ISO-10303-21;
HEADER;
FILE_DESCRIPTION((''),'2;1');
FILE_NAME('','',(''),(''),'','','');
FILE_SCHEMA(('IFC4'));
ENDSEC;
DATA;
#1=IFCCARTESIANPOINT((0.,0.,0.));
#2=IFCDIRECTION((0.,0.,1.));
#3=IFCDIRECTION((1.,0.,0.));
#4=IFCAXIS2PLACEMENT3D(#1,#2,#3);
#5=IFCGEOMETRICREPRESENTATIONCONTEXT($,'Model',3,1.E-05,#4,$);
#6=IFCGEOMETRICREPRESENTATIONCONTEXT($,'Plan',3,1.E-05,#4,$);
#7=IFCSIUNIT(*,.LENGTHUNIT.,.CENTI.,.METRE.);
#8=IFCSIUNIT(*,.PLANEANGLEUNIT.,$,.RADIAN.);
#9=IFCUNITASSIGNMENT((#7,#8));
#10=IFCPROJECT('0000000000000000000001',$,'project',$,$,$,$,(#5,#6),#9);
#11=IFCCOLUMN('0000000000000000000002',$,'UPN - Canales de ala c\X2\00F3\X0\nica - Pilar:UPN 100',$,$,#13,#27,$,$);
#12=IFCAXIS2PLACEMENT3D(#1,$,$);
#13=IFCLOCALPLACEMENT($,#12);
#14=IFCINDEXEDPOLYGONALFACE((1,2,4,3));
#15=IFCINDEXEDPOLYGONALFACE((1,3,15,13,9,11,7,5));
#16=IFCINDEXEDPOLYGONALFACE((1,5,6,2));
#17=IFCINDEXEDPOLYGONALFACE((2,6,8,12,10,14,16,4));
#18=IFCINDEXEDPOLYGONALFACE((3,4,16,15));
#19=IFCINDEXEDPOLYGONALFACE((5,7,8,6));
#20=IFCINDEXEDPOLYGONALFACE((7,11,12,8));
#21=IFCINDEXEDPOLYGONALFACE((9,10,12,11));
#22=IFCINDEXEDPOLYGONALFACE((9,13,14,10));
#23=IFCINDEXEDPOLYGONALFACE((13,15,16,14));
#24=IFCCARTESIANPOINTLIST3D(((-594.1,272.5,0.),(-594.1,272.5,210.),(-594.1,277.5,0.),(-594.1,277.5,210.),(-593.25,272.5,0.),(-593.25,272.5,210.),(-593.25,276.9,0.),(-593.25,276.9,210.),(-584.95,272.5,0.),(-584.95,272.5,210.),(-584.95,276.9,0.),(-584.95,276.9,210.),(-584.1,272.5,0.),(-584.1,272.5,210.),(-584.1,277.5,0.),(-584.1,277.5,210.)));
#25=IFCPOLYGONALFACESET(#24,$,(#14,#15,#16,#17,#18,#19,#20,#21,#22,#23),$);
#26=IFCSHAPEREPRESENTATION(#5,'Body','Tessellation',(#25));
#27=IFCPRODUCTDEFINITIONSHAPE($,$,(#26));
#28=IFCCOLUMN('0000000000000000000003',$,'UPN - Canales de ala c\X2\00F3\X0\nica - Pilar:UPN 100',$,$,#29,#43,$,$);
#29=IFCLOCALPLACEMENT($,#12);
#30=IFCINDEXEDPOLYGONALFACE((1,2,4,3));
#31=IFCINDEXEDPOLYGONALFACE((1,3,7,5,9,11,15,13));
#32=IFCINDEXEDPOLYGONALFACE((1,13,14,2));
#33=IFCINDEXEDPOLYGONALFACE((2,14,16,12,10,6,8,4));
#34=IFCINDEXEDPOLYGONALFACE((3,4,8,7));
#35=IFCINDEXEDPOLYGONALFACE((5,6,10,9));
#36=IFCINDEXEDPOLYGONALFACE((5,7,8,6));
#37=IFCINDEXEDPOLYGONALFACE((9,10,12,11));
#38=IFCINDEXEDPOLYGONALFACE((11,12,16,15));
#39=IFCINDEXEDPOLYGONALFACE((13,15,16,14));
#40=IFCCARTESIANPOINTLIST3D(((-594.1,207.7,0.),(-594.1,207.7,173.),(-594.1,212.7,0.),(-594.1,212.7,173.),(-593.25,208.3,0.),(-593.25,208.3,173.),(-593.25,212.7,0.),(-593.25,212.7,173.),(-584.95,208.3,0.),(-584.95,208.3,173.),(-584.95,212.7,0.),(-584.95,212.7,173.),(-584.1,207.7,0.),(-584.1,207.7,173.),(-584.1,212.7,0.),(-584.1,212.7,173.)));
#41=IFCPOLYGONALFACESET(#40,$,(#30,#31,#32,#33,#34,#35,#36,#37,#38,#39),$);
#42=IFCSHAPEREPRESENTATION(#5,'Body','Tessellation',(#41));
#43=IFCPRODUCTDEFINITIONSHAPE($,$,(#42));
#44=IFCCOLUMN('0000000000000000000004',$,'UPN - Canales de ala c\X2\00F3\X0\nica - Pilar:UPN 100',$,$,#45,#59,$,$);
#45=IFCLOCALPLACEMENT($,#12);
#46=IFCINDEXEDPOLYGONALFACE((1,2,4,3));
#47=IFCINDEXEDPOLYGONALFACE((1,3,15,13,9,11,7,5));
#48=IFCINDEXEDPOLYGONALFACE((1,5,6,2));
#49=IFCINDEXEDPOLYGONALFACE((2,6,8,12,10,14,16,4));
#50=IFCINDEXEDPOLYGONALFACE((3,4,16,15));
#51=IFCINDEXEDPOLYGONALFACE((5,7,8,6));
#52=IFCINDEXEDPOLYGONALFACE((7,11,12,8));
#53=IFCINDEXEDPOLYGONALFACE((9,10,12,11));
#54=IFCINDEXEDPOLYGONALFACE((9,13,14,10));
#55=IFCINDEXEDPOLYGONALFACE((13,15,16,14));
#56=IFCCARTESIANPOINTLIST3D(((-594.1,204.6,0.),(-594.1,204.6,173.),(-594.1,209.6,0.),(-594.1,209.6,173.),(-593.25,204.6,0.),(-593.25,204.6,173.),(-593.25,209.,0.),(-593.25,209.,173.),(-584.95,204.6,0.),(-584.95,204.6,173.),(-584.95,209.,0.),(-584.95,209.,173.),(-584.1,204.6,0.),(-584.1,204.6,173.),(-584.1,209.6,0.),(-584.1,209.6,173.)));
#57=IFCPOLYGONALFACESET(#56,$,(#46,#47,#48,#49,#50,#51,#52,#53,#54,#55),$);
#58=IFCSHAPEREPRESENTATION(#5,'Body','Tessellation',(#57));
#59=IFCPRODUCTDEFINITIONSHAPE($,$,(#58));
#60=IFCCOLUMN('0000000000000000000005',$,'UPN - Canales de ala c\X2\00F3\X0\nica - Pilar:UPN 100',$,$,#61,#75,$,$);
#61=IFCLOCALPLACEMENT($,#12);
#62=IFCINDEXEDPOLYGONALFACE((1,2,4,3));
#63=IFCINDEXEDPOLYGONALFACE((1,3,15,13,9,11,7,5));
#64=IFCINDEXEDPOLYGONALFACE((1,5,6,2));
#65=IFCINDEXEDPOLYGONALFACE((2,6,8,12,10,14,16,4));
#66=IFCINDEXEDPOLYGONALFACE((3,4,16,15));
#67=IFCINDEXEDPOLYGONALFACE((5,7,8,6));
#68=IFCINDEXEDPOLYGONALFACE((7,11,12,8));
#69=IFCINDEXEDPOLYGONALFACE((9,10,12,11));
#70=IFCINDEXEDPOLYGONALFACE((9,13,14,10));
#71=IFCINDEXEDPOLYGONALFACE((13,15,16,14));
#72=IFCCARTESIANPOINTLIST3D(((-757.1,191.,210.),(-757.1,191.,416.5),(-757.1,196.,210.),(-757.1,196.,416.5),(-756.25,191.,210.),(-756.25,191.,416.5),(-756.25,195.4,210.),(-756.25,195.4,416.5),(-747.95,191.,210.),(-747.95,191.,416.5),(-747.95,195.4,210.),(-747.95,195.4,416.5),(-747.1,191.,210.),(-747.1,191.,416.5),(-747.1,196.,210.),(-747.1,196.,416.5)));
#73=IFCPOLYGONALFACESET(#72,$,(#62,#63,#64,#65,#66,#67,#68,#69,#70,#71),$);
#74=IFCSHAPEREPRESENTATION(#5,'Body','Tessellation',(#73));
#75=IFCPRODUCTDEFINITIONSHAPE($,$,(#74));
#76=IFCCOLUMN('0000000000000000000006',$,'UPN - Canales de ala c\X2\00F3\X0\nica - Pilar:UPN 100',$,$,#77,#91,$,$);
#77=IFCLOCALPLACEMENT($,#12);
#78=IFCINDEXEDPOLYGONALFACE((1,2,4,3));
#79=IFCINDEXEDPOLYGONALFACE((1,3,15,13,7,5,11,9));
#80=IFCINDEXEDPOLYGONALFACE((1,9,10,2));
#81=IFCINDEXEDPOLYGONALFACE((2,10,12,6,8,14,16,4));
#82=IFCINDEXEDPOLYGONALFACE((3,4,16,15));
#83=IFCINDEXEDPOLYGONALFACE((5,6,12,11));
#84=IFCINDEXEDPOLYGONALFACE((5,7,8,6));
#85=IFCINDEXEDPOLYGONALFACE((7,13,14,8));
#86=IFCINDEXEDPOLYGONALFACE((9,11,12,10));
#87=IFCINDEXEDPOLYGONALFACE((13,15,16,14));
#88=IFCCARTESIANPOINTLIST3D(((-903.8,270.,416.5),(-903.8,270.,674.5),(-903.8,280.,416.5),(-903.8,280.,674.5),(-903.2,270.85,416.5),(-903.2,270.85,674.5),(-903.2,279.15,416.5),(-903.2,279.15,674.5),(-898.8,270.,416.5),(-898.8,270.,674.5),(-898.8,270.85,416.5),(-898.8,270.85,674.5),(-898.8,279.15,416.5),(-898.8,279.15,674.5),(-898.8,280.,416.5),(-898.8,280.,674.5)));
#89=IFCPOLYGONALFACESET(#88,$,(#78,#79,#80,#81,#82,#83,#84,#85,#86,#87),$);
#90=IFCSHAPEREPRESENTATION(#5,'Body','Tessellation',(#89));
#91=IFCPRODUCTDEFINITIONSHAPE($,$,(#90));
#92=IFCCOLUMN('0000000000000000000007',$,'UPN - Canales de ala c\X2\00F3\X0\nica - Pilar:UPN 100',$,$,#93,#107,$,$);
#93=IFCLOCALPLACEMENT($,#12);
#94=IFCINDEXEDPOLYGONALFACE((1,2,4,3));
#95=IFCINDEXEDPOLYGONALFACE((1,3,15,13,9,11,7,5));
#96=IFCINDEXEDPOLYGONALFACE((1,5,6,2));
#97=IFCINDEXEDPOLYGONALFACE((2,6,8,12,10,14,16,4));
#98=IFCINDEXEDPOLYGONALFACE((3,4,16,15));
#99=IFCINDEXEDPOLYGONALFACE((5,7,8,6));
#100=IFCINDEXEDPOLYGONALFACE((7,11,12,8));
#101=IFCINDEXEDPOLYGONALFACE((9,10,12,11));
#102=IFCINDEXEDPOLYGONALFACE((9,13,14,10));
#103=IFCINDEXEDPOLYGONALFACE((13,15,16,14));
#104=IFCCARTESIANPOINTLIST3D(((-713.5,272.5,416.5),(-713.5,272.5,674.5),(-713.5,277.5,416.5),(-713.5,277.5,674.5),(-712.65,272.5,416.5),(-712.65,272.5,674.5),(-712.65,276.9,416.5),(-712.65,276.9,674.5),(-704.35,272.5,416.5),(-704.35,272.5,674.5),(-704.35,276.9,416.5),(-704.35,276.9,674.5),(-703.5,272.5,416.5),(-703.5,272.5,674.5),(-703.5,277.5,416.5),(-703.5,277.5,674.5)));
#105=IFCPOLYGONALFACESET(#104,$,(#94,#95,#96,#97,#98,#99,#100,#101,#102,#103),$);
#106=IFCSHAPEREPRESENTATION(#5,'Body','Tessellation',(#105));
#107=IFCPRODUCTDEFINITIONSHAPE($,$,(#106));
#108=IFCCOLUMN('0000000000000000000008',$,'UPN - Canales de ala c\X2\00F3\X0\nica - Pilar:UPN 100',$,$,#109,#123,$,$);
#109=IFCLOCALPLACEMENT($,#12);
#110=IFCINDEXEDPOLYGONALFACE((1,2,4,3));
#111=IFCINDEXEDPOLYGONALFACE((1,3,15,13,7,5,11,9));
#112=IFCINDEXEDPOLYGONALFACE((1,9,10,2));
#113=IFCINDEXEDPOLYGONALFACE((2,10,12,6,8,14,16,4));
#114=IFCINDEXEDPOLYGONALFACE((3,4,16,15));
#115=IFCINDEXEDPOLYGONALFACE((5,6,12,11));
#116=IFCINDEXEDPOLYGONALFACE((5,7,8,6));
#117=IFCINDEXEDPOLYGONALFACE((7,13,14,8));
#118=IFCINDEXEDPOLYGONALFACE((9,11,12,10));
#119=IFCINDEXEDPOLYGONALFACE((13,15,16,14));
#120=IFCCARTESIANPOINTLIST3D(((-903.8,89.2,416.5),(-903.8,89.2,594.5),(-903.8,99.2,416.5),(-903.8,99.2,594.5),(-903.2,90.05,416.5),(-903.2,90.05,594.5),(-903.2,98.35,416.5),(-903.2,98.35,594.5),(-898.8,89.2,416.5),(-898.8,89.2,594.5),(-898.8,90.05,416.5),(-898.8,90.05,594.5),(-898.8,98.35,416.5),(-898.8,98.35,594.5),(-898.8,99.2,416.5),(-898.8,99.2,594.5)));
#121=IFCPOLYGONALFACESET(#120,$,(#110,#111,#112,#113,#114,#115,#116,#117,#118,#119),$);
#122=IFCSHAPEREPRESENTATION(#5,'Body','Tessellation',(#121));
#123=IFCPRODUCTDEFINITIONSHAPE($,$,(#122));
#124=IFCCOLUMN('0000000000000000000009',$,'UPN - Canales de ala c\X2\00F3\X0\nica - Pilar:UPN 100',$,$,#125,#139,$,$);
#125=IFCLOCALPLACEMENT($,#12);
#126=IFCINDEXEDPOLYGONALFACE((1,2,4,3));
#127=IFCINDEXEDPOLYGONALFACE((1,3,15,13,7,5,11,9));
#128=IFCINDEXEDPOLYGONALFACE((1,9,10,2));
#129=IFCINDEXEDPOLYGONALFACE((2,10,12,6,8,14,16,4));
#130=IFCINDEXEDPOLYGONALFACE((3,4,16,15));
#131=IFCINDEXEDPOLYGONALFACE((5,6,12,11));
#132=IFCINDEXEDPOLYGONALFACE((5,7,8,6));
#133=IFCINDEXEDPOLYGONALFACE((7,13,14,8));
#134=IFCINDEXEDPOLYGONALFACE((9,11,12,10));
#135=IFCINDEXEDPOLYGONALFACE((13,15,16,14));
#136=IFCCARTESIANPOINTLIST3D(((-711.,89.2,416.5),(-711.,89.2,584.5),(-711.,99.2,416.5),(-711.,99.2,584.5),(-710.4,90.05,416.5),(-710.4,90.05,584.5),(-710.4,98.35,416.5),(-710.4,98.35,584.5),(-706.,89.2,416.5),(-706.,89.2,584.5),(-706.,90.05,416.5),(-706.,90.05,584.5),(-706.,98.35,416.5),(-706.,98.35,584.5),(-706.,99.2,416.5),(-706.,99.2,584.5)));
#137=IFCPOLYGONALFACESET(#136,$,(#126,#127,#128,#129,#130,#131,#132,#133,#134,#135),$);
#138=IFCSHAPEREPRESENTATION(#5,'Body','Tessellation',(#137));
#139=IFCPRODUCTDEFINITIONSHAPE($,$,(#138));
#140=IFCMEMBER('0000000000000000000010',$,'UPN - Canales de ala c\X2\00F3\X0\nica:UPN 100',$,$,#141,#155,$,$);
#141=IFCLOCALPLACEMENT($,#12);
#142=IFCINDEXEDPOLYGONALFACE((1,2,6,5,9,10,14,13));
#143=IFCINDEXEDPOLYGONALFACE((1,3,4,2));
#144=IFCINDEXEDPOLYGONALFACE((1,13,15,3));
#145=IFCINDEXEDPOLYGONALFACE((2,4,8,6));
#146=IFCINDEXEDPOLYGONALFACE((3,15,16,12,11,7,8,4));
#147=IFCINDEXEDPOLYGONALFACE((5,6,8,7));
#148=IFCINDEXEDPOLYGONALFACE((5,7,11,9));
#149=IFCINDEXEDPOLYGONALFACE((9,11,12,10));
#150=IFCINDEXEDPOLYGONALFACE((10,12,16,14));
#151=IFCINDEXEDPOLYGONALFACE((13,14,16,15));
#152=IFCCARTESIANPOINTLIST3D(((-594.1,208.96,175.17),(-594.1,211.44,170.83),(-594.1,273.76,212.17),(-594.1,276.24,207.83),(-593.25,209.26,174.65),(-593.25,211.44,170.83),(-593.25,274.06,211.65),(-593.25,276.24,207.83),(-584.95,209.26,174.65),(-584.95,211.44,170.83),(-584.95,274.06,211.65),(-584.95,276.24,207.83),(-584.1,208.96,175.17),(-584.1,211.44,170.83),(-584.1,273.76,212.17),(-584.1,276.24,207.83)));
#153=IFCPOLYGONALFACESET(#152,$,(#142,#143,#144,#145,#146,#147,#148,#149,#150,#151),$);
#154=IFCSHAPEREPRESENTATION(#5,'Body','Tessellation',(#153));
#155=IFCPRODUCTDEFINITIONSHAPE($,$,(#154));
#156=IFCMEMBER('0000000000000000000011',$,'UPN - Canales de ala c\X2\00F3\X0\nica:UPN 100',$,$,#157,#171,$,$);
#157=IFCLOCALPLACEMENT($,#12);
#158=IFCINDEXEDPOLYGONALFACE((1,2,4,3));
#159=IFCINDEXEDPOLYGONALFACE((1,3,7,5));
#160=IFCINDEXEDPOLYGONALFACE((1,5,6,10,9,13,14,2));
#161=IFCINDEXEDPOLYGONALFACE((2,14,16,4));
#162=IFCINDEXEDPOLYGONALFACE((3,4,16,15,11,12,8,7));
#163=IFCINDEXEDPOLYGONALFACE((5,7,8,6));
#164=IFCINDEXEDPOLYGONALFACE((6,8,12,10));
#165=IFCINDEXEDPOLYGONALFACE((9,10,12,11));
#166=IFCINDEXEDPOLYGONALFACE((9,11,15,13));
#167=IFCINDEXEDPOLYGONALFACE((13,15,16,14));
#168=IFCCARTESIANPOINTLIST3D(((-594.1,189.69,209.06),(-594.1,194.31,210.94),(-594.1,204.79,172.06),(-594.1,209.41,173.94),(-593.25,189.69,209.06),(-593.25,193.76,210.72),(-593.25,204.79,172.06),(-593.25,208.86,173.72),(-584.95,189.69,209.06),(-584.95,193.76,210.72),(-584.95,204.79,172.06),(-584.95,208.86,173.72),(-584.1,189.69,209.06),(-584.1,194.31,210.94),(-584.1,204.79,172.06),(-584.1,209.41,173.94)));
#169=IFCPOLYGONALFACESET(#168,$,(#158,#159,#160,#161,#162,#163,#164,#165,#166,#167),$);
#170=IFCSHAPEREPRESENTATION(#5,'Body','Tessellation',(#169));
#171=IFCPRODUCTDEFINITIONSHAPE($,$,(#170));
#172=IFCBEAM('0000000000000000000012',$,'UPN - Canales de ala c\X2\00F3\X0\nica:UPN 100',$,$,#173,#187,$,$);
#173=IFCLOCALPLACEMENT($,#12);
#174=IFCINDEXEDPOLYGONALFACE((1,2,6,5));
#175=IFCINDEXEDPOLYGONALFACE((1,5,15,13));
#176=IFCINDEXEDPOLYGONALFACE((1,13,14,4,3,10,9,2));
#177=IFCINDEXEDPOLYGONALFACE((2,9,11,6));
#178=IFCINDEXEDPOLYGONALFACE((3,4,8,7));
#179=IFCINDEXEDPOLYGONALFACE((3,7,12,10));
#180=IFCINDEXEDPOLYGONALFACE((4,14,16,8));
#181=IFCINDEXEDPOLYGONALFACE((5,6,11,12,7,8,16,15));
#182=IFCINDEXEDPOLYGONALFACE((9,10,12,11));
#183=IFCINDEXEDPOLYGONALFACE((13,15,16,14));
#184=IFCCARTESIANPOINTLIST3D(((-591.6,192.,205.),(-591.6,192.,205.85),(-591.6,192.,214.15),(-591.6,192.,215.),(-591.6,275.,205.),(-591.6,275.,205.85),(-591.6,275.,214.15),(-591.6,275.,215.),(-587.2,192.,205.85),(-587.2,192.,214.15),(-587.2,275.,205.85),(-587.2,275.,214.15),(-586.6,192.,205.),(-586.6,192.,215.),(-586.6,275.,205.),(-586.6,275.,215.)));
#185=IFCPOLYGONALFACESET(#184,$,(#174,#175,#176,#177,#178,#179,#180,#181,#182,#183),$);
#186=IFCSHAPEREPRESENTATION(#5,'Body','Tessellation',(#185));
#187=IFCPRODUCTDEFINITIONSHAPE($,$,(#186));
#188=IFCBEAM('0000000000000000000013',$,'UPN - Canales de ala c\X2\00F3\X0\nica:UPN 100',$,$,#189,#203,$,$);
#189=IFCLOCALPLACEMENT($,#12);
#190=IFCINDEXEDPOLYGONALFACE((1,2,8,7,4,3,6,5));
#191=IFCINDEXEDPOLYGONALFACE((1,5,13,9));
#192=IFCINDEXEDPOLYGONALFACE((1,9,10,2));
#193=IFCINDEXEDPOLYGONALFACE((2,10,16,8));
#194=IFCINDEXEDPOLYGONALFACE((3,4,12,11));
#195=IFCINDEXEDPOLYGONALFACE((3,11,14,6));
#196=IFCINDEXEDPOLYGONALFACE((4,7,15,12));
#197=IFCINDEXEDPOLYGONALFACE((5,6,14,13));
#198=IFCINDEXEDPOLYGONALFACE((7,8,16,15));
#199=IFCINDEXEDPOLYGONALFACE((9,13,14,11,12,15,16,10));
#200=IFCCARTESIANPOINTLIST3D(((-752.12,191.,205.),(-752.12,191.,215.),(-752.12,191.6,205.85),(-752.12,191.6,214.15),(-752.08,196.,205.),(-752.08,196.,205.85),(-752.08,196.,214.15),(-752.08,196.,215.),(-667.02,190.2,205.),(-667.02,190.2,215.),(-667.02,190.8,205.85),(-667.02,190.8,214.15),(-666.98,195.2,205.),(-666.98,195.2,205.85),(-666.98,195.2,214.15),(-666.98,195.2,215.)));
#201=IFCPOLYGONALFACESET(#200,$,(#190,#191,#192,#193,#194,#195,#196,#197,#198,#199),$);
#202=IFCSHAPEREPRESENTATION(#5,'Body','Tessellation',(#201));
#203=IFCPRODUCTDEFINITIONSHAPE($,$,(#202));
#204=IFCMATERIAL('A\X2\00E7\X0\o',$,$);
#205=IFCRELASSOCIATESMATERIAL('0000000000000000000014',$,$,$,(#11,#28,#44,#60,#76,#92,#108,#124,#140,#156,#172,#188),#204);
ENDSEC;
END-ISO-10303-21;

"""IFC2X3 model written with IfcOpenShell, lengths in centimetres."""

from ifc_helpers import new_model, si_unit, frame, frame_2d, origin_with_axes, origin_2d_with_axis, place, context, project, u_section, extrude, material, element, save


model = new_model("IFC2X3")

# Units and contexts
model_context = context("Model", 3, precision=1e-05, world=origin_with_axes())
plan_context = context("Plan", 3, precision=1e-05, world=origin_with_axes())
ifc_project = project(units=[si_unit("LENGTHUNIT", "METRE", prefix="CENTI"), si_unit("PLANEANGLEUNIT", "RADIAN")], contexts=[model_context, plan_context])

# Columns
ifc_material = material(Name="Aço")
column_1_placement = place(None, frame((-589.1, 275.0, 0.0), z_axis=(0.0, 0.0, 1.0), x_axis=(0.0, -1.0, 0.0)))
element("IfcColumn", 1, at=column_1_placement, material=ifc_material, Name="UPN - Canales de ala cónica - Pilar:UPN 100", context=model_context, shape_type="SweptSolid", body=[
    extrude(u_section(Depth=10.0, FlangeWidth=5.0, WebThickness=0.6, FlangeThickness=0.85, FilletRadius=0.0, EdgeRadius=0.0, FlangeSlope=0.0, CentreOfGravityInX=0.0, at=origin_2d_with_axis()), origin_with_axes(), (0.0, 0.0, 1.0), 210.0),
])
for number, where, z_axis, x_axis, name in (
    (2, (-589.1, 210.2, 0.0), (0.0, 0.0, 1.0), (0.0, 1.0, 0.0), "UPN - Canales de ala cónica - Pilar:UPN 100"),
    (3, (-589.1, 207.1, 0.0), (0.0, 0.0, 1.0), (0.0, -1.0, 0.0), "UPN - Canales de ala cónica - Pilar:UPN 100"),
):
    element("IfcColumn", number, at=place(None, frame(where, z_axis=z_axis, x_axis=x_axis)), material=ifc_material, Name=name, context=model_context, shape_type="SweptSolid", body=[
        extrude(u_section(Depth=10.0, FlangeWidth=5.0, WebThickness=0.6, FlangeThickness=0.85, FilletRadius=0.0, EdgeRadius=0.0, FlangeSlope=0.0, CentreOfGravityInX=0.0, at=origin_2d_with_axis()), origin_with_axes(), (0.0, 0.0, 1.0), 173.0),
    ])
column_2_placement = place(None, frame((-752.1, 193.5, 210.0), z_axis=(0.0, 0.0, 1.0), x_axis=(0.0, -1.0, 0.0)))
element("IfcColumn", 4, at=column_2_placement, material=ifc_material, Name="UPN - Canales de ala cónica - Pilar:UPN 100", context=model_context, shape_type="SweptSolid", body=[
    extrude(u_section(Depth=10.0, FlangeWidth=5.0, WebThickness=0.6, FlangeThickness=0.85, FilletRadius=0.0, EdgeRadius=0.0, FlangeSlope=0.0, CentreOfGravityInX=0.0, at=origin_2d_with_axis()), origin_with_axes(), (0.0, 0.0, 1.0), 206.5),
])
for number, where, z_axis, x_axis, name in (
    (5, (-901.3, 275.0, 416.5), (0.0, 0.0, 1.0), (1.0, 0.0, 0.0), "UPN - Canales de ala cónica - Pilar:UPN 100"),
    (6, (-708.5, 275.0, 416.5), (0.0, 0.0, 1.0), (0.0, -1.0, 0.0), "UPN - Canales de ala cónica - Pilar:UPN 100"),
):
    element("IfcColumn", number, at=place(None, frame(where, z_axis=z_axis, x_axis=x_axis)), material=ifc_material, Name=name, context=model_context, shape_type="SweptSolid", body=[
        extrude(u_section(Depth=10.0, FlangeWidth=5.0, WebThickness=0.6, FlangeThickness=0.85, FilletRadius=0.0, EdgeRadius=0.0, FlangeSlope=0.0, CentreOfGravityInX=0.0, at=origin_2d_with_axis()), origin_with_axes(), (0.0, 0.0, 1.0), 258.0),
    ])
column_3_placement = place(None, frame((-901.3, 94.2, 416.5), z_axis=(0.0, 0.0, 1.0), x_axis=(1.0, 0.0, 0.0)))
element("IfcColumn", 7, at=column_3_placement, material=ifc_material, Name="UPN - Canales de ala cónica - Pilar:UPN 100", context=model_context, shape_type="SweptSolid", body=[
    extrude(u_section(Depth=10.0, FlangeWidth=5.0, WebThickness=0.6, FlangeThickness=0.85, FilletRadius=0.0, EdgeRadius=0.0, FlangeSlope=0.0, CentreOfGravityInX=0.0, at=origin_2d_with_axis()), origin_with_axes(), (0.0, 0.0, 1.0), 178.0),
])
column_4_placement = place(None, frame((-708.5, 94.2, 416.5), z_axis=(0.0, 0.0, 1.0), x_axis=(1.0, 0.0, 0.0)))
element("IfcColumn", 8, at=column_4_placement, material=ifc_material, Name="UPN - Canales de ala cónica - Pilar:UPN 100", context=model_context, shape_type="SweptSolid", body=[
    extrude(u_section(Depth=10.0, FlangeWidth=5.0, WebThickness=0.6, FlangeThickness=0.85, FilletRadius=0.0, EdgeRadius=0.0, FlangeSlope=0.0, CentreOfGravityInX=0.0, at=origin_2d_with_axis()), origin_with_axes(), (0.0, 0.0, 1.0), 168.0),
])

# Members
member_1_placement = place(None, frame((-589.1, 210.2, 173.0), z_axis=(0.0, 0.868408, 0.49585), x_axis=(0.0, 0.49585, -0.868408)))
element("IfcMember", 9, at=member_1_placement, material=ifc_material, Name="UPN - Canales de ala cónica:UPN 100", context=model_context, shape_type="SweptSolid", body=[
    extrude(u_section(Depth=10.0, FlangeWidth=5.0, WebThickness=0.6, FlangeThickness=0.85, FilletRadius=0.0, EdgeRadius=0.0, FlangeSlope=0.0, CentreOfGravityInX=0.0, at=origin_2d_with_axis()), origin_with_axes(), (0.0, 0.0, 1.0), 74.62),
])
member_2_placement = place(None, frame((-589.1, 207.1, 173.0), z_axis=(0.0, -0.377853, 0.925865), x_axis=(0.0, -0.925865, -0.377853)))
element("IfcMember", 10, at=member_2_placement, material=ifc_material, Name="UPN - Canales de ala cónica:UPN 100", context=model_context, shape_type="SweptSolid", body=[
    extrude(u_section(Depth=10.0, FlangeWidth=5.0, WebThickness=0.6, FlangeThickness=0.85, FilletRadius=0.0, EdgeRadius=0.0, FlangeSlope=0.0, CentreOfGravityInX=0.0, at=origin_2d_with_axis()), origin_with_axes(), (0.0, 0.0, 1.0), 39.96),
])

# Beams
beam_1_placement = place(None, frame((-589.1, 192.0, 210.0), z_axis=(0.0, 1.0, 0.0), x_axis=(-1.0, 0.0, 0.0)))
element("IfcBeam", 11, at=beam_1_placement, material=ifc_material, Name="UPN - Canales de ala cónica:UPN 100", context=model_context, shape_type="SweptSolid", body=[
    extrude(u_section(Depth=10.0, FlangeWidth=5.0, WebThickness=0.6, FlangeThickness=0.85, FilletRadius=0.0, EdgeRadius=0.0, FlangeSlope=0.0, CentreOfGravityInX=0.0, at=origin_2d_with_axis()), origin_with_axes(), (0.0, 0.0, 1.0), 83.0),
])
beam_2_placement = place(None, frame((-667.0, 192.7, 210.0), z_axis=(-0.999956, 0.0094, 0.0), x_axis=(0.0094, 0.999956, 0.0)))
element("IfcBeam", 12, at=beam_2_placement, material=ifc_material, Name="UPN - Canales de ala cónica:UPN 100", context=model_context, shape_type="SweptSolid", body=[
    extrude(u_section(Depth=10.0, FlangeWidth=5.0, WebThickness=0.6, FlangeThickness=0.85, FilletRadius=0.0, EdgeRadius=0.0, FlangeSlope=0.0, CentreOfGravityInX=0.0, at=frame_2d((0.0, 0.0), x_axis=(1.0, 0.0))), origin_with_axes(), (0.0, 0.0, 1.0), 85.1),
])

save(model, "model.ifc")
